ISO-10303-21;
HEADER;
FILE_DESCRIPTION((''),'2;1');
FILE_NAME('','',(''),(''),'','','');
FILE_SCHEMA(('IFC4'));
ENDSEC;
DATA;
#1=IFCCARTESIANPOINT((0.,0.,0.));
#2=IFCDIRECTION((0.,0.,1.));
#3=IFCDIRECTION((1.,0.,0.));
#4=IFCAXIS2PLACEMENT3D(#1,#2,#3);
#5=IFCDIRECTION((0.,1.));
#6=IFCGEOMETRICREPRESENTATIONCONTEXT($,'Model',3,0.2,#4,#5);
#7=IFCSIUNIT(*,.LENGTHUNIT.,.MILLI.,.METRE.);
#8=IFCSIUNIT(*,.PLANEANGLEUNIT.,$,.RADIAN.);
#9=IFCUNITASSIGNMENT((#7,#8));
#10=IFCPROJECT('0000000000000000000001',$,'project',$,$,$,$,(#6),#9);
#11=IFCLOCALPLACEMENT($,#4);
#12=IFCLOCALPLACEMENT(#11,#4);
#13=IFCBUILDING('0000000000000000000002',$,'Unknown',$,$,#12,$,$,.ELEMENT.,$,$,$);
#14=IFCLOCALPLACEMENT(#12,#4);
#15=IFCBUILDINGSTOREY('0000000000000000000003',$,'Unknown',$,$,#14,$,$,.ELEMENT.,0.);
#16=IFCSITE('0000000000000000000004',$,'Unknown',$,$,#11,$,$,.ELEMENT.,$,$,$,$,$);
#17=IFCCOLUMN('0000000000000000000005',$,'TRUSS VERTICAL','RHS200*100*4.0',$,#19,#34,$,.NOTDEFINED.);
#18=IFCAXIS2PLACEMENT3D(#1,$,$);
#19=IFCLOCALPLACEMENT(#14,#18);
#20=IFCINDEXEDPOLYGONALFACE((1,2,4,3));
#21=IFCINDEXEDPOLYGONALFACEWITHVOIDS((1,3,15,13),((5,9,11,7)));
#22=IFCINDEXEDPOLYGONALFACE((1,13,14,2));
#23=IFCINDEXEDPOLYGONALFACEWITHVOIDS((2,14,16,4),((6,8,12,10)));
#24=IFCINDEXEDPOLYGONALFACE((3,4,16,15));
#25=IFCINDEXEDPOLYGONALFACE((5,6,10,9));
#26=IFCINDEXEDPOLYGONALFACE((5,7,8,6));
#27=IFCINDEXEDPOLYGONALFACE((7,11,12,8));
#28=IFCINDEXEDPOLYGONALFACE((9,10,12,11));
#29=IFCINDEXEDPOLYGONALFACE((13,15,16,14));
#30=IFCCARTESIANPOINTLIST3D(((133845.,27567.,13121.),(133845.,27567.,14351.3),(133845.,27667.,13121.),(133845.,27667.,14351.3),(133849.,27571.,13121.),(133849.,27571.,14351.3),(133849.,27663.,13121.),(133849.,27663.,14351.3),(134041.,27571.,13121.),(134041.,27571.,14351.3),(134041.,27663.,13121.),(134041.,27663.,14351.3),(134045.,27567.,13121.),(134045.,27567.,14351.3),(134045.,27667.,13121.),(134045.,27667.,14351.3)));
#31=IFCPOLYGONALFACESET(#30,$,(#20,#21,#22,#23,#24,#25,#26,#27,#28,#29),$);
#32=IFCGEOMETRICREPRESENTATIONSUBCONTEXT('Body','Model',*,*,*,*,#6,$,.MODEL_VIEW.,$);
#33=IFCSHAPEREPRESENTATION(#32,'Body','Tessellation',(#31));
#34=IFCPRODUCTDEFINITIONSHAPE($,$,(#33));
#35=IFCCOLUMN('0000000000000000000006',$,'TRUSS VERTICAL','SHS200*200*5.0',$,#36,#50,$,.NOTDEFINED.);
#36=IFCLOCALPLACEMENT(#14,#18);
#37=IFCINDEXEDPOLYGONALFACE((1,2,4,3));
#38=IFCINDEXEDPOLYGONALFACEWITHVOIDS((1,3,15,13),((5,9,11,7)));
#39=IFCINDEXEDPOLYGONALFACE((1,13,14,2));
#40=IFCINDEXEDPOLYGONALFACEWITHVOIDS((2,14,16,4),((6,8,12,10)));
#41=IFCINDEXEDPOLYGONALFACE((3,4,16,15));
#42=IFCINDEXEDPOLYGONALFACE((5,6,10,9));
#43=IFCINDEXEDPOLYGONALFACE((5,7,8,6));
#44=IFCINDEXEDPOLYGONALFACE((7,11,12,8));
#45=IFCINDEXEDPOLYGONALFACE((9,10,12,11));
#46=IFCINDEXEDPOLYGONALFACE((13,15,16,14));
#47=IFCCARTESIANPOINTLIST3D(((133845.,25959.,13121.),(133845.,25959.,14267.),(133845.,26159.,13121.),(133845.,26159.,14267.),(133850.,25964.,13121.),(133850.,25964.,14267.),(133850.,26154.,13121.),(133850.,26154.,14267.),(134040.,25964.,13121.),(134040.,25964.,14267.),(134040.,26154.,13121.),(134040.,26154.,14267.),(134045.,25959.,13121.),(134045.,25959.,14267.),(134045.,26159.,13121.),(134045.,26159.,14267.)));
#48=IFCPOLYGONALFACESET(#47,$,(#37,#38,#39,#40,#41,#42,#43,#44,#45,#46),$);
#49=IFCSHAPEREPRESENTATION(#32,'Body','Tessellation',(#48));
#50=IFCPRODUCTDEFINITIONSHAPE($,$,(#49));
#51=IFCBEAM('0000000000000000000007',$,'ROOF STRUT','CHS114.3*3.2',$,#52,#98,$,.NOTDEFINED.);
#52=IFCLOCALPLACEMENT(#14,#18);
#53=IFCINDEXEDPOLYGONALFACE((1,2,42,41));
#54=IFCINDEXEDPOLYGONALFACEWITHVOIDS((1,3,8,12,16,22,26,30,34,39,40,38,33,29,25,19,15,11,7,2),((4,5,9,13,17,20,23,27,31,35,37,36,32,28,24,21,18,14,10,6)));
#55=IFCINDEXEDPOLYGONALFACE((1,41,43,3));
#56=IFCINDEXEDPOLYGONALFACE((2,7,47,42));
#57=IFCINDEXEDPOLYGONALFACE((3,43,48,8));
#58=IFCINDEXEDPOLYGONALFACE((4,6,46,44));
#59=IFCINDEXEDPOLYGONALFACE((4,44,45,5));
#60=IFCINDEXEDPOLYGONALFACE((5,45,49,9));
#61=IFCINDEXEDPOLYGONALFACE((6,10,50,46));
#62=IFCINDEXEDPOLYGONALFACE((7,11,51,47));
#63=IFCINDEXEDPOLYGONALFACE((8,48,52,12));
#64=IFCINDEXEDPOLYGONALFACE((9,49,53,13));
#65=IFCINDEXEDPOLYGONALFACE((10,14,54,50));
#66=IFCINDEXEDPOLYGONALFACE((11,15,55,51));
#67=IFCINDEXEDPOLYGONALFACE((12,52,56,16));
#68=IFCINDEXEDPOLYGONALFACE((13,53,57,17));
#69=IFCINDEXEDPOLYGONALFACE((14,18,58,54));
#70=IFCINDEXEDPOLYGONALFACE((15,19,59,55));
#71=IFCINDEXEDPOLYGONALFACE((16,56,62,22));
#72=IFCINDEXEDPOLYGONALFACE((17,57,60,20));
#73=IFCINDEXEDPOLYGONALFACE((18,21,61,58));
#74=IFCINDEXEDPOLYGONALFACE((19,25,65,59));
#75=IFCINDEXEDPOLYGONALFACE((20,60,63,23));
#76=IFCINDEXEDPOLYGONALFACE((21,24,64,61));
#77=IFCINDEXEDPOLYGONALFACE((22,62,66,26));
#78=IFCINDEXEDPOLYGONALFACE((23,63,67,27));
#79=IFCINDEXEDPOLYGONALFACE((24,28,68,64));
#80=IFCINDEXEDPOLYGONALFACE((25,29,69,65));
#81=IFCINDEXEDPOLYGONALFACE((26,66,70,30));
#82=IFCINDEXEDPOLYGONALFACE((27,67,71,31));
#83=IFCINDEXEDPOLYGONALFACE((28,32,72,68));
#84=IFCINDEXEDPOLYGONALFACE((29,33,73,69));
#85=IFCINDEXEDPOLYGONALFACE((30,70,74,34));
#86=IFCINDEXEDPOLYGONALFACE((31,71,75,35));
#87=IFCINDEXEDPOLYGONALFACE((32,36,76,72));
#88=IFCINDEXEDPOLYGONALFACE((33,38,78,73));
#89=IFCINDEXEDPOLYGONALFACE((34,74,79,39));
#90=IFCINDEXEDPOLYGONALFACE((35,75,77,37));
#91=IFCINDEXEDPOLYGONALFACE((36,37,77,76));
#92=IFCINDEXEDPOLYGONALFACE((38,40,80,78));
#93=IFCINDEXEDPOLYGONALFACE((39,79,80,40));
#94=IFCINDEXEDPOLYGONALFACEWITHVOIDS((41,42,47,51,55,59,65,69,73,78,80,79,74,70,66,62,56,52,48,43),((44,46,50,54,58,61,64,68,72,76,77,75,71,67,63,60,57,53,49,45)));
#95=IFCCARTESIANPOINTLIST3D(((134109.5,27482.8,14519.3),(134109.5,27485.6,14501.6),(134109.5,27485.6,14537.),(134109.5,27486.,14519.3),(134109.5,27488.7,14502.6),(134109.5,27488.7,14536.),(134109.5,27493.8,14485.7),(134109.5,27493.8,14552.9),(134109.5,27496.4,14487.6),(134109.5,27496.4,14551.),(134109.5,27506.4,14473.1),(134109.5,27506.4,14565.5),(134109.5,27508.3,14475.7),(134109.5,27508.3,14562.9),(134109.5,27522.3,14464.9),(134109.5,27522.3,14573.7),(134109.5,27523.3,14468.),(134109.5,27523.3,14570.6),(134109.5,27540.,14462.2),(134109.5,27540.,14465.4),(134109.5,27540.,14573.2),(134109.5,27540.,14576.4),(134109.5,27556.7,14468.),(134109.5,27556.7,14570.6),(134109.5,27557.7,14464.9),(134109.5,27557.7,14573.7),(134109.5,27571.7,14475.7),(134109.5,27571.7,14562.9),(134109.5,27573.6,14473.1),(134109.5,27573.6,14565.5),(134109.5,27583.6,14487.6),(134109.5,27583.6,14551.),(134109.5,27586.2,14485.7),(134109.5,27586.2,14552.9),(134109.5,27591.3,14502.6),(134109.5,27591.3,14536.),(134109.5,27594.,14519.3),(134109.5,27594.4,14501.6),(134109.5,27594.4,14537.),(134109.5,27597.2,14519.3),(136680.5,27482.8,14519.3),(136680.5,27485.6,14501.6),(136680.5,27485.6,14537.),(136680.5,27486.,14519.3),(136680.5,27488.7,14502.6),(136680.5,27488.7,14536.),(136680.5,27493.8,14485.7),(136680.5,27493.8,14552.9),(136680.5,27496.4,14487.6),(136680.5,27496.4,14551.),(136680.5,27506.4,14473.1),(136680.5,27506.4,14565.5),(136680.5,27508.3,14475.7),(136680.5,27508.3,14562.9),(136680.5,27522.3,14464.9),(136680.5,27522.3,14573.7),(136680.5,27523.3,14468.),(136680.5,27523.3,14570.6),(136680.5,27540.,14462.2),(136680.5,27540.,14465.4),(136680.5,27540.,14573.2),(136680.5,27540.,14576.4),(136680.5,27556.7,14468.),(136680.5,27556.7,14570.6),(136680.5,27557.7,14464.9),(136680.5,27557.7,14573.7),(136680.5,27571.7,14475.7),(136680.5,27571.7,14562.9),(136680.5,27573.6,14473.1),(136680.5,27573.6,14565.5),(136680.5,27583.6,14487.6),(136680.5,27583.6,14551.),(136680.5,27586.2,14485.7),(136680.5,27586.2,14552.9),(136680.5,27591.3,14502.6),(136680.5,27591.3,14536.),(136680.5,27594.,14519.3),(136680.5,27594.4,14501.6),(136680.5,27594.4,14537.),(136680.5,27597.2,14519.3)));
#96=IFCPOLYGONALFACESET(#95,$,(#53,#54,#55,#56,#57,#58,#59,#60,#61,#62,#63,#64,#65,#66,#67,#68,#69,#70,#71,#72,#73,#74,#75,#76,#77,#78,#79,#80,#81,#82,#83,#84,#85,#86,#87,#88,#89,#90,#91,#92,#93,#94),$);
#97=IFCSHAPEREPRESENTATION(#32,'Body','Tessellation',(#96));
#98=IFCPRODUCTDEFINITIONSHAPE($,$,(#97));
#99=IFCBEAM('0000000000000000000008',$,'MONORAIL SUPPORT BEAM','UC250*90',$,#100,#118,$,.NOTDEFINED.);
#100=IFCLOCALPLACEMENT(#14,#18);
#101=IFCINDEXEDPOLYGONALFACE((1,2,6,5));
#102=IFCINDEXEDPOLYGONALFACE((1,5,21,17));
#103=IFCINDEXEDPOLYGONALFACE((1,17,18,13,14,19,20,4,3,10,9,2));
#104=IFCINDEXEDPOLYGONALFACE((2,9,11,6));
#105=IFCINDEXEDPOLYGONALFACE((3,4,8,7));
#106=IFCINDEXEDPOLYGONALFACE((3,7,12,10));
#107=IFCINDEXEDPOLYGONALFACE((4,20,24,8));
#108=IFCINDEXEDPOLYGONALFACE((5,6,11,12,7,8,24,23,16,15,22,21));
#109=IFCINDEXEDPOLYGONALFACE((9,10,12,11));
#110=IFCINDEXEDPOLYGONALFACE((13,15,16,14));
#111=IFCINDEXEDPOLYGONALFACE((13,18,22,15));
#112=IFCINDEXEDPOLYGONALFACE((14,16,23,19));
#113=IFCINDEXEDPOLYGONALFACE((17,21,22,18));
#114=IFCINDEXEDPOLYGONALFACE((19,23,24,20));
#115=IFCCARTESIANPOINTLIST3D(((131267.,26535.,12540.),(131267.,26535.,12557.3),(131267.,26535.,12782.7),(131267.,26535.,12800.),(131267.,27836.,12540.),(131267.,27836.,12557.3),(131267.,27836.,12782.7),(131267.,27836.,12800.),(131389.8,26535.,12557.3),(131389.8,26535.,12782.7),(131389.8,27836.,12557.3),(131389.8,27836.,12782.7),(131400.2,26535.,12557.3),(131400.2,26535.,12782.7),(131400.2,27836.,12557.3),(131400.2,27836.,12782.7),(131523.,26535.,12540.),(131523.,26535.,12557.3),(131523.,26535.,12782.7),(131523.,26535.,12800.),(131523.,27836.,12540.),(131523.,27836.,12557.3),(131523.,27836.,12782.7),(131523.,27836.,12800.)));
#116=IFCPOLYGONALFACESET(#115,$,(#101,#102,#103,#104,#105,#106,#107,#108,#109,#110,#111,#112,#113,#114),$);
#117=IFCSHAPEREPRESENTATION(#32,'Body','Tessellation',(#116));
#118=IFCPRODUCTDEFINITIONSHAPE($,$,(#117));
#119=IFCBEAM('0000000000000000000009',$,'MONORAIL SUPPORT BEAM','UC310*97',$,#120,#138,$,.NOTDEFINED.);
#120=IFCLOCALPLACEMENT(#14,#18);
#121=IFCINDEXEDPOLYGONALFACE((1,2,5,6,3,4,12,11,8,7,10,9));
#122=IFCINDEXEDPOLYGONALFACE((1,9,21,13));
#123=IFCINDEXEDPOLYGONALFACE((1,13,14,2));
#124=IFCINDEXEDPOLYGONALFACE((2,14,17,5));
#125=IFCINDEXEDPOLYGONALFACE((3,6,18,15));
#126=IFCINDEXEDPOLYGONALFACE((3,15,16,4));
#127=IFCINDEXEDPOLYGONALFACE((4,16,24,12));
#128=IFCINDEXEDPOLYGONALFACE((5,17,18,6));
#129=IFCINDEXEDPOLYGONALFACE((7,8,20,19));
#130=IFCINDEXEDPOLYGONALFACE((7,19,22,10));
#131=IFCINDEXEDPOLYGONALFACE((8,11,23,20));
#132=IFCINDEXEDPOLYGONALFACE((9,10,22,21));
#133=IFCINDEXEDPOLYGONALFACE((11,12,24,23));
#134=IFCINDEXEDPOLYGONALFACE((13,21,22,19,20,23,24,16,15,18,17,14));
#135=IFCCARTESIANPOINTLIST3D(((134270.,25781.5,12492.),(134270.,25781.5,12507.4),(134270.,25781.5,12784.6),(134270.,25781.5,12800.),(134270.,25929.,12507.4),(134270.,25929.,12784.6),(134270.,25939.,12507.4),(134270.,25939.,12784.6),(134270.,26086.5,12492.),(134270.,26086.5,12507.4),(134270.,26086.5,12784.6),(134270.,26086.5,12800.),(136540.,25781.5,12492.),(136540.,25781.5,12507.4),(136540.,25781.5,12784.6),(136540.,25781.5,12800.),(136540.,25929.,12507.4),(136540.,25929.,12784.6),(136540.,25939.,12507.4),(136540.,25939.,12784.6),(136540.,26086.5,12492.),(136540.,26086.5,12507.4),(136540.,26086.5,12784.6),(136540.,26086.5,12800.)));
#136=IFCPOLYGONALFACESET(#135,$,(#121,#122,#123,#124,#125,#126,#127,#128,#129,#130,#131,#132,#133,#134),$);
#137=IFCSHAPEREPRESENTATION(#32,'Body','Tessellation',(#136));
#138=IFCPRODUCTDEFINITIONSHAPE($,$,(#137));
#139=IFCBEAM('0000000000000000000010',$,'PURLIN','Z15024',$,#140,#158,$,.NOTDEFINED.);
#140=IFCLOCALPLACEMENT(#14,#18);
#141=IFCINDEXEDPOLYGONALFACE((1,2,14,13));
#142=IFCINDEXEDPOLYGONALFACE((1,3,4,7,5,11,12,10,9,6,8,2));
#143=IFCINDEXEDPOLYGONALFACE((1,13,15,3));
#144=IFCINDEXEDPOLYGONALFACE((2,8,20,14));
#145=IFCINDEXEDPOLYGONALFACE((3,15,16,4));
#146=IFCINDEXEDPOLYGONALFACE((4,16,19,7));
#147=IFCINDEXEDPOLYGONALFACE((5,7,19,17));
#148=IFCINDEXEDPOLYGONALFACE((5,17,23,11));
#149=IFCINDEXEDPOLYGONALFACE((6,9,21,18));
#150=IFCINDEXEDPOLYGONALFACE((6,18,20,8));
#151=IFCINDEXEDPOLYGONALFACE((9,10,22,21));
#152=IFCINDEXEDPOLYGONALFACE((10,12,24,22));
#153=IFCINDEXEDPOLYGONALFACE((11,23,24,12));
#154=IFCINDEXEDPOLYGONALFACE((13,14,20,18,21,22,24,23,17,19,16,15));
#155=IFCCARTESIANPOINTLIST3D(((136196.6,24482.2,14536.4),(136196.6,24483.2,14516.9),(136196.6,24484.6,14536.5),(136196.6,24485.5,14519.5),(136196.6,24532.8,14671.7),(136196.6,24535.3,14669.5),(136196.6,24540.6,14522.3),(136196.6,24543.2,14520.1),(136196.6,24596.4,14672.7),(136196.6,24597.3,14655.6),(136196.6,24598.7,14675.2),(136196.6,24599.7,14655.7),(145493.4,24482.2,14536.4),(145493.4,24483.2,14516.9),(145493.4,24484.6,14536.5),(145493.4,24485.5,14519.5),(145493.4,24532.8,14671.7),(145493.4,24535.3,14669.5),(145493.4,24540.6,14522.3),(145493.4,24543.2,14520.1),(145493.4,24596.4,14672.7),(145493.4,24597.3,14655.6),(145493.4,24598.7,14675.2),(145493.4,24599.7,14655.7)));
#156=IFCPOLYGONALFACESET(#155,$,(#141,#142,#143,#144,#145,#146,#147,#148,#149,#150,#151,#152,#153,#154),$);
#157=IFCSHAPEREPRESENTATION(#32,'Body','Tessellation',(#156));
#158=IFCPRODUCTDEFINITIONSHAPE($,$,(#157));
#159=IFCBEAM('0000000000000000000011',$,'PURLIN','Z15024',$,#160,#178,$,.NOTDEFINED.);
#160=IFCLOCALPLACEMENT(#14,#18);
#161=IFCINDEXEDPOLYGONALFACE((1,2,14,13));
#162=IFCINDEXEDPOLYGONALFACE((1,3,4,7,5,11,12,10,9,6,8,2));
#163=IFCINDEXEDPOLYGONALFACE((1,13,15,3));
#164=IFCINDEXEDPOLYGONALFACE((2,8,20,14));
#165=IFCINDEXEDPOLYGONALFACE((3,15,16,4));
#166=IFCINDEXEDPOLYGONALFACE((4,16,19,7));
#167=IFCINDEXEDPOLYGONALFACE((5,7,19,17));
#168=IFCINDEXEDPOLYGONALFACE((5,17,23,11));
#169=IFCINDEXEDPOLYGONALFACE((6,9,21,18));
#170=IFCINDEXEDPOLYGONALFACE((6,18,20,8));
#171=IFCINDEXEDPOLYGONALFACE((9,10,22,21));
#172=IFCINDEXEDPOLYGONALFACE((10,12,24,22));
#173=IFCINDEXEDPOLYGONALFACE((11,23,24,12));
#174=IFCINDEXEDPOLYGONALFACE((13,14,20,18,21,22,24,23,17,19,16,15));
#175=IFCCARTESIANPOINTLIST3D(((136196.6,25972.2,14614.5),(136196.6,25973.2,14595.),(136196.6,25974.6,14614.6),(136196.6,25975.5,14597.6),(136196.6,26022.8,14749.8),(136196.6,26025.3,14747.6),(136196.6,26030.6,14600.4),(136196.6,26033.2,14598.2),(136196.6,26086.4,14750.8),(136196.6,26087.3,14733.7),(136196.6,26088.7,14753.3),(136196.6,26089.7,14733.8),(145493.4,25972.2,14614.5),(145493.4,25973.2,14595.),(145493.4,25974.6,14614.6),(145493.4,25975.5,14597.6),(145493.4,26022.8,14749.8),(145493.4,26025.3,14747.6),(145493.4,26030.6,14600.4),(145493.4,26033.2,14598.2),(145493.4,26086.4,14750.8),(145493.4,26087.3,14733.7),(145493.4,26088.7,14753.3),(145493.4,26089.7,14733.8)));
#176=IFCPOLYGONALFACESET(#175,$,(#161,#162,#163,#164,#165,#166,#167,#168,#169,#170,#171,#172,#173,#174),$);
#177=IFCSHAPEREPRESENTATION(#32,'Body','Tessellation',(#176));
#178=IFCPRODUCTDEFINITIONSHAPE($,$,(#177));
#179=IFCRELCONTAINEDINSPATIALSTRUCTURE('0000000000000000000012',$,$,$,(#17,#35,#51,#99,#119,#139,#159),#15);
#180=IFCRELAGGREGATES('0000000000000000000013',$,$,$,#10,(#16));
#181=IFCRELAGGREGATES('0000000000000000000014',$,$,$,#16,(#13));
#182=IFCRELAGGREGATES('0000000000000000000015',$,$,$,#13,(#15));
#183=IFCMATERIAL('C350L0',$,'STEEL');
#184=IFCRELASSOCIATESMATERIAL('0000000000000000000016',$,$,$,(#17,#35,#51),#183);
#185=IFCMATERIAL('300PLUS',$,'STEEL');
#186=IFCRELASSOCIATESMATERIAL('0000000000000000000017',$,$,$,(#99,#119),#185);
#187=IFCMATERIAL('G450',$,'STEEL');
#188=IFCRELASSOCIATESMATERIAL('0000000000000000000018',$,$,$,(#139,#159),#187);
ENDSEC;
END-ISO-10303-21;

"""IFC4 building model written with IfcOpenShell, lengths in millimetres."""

from ifc_helpers import new_model, si_unit, direction, frame, origin_with_axes, place, context, subcontext, project, spatial, line, indexed_curve, outline, extrude, material, element, save


model = new_model("IFC4")

# Units and contexts
model_context = context("Model", 3, precision=0.2, world=origin_with_axes(), true_north=direction((0.0, 1.0)))
body_context = subcontext(model_context, "Body", "Model", "MODEL_VIEW")
ifc_project = project(units=[si_unit("LENGTHUNIT", "METRE", prefix="MILLI"), si_unit("PLANEANGLEUNIT", "RADIAN")], contexts=[model_context])

# Site, building, storey
site_placement = place(None, origin_with_axes())
site = spatial("IfcSite", under=ifc_project, at=site_placement, Name="Unknown", CompositionType="ELEMENT")
building_placement = place(site_placement, origin_with_axes())
building = spatial("IfcBuilding", under=site, at=building_placement, Name="Unknown", CompositionType="ELEMENT")
storey_placement = place(building_placement, origin_with_axes())
storey = spatial("IfcBuildingStorey", under=building, at=storey_placement, Name="Unknown", CompositionType="ELEMENT", Elevation=0.0)

# Columns
ifc_material_1 = material(Name="C350L0", Category="STEEL")
column_1_placement = place(storey_placement, frame((133945.0, 27617.0, 13121.0), z_axis=(0.0, -1.0, 0.0), x_axis=(0.0, 0.0, 1.0)))
element("IfcColumn", 1, at=column_1_placement, inside=storey, material=ifc_material_1, Name="TRUSS VERTICAL", Description="RHS200*100*4.0", PredefinedType="NOTDEFINED", context=body_context, shape_type="SolidModel", body=[
    extrude(outline(indexed_curve([(-50.0, -100.0), (50.0, -100.0), (50.0, 100.0), (-50.0, 100.0)], segments=[line(1, 2, 3, 4, 1)]), holes=[indexed_curve([(-46.0, -96.0), (-46.0, 96.0), (46.0, 96.0), (46.0, -96.0)], segments=[line(1, 2, 3, 4, 1)])]), frame((0.0, 0.0, 0.0), z_axis=(-1.0, 0.0, 0.0), x_axis=(0.0, 0.0, 1.0)), (0.0, 0.0, -1.0), 1230.3),
])
column_2_placement = place(storey_placement, frame((133945.0, 26059.0, 13121.0), z_axis=(-1.0, 0.0, 0.0), x_axis=(0.0, 0.0, 1.0)))
element("IfcColumn", 2, at=column_2_placement, inside=storey, material=ifc_material_1, Name="TRUSS VERTICAL", Description="SHS200*200*5.0", PredefinedType="NOTDEFINED", context=body_context, shape_type="SolidModel", body=[
    extrude(outline(indexed_curve([(-100.0, -100.0), (100.0, -100.0), (100.0, 100.0), (-100.0, 100.0)], segments=[line(1, 2, 3, 4, 1)]), holes=[indexed_curve([(-95.0, -95.0), (-95.0, 95.0), (95.0, 95.0), (95.0, -95.0)], segments=[line(1, 2, 3, 4, 1)])]), frame((0.0, 0.0, 0.0), z_axis=(-1.0, 0.0, 0.0), x_axis=(0.0, 0.0, 1.0)), (0.0, 0.0, -1.0), 1146.0),
])

# Beams
beam_1_placement = place(storey_placement, frame((134109.5, 27540.0, 14519.3), z_axis=(0.0, 0.0, 1.0), x_axis=(1.0, 0.0, 0.0)))
element("IfcBeam", 3, at=beam_1_placement, inside=storey, material=ifc_material_1, Name="ROOF STRUT", Description="CHS114.3*3.2", PredefinedType="NOTDEFINED", context=body_context, shape_type="SolidModel", body=[
    extrude(outline(indexed_curve([(57.1, 0.0), (54.4, 17.7), (46.2, 33.6), (33.6, 46.2), (17.7, 54.4), (0.0, 57.1), (-17.7, 54.4), (-33.6, 46.2), (-46.2, 33.6), (-54.4, 17.7), (-57.1, 0.0), (-54.4, -17.7), (-46.2, -33.6), (-33.6, -46.2), (-17.7, -54.4), (0.0, -57.1), (17.7, -54.4), (33.6, -46.2), (46.2, -33.6), (54.4, -17.7)], segments=[line(1, 2, 3, 4, 5, 6, 7, 8, 9, 10, 11, 12, 13, 14, 15, 16, 17, 18, 19, 20, 1)]), holes=[indexed_curve([(54.0, 0.0), (51.3, -16.7), (43.6, -31.7), (31.7, -43.6), (16.7, -51.3), (0.0, -54.0), (-16.7, -51.3), (-31.7, -43.6), (-43.6, -31.7), (-51.3, -16.7), (-54.0, 0.0), (-51.3, 16.7), (-43.6, 31.7), (-31.7, 43.6), (-16.7, 51.3), (0.0, 54.0), (16.7, 51.3), (31.7, 43.6), (43.6, 31.7), (51.3, 16.7)], segments=[line(1, 2, 3, 4, 5, 6, 7, 8, 9, 10, 11, 12, 13, 14, 15, 16, 17, 18, 19, 20, 1)])]), frame((0.0, 0.0, 0.0), z_axis=(-1.0, 0.0, 0.0), x_axis=(0.0, 0.0, 1.0)), (0.0, 0.0, -1.0), 2571.0),
])
ifc_material_2 = material(Name="300PLUS", Category="STEEL")
beam_2_placement = place(storey_placement, frame((131395.0, 26535.0, 12670.0), z_axis=(1.0, 0.0, 0.0), x_axis=(0.0, 1.0, 0.0)))
element("IfcBeam", 4, at=beam_2_placement, inside=storey, material=ifc_material_2, Name="MONORAIL SUPPORT BEAM", Description="UC250*90", PredefinedType="NOTDEFINED", context=body_context, shape_type="SolidModel", body=[
    extrude(outline(indexed_curve([(-128.0, -130.0), (128.0, -130.0), (128.0, -112.7), (5.2, -112.7), (5.2, 112.7), (128.0, 112.7), (128.0, 130.0), (-128.0, 130.0), (-128.0, 112.7), (-5.2, 112.7), (-5.2, -112.7), (-128.0, -112.7)], segments=[line(1, 2, 3, 4, 5, 6, 7, 8, 9, 10, 11, 12, 1)])), frame((0.0, 0.0, 0.0), z_axis=(-1.0, 0.0, 0.0), x_axis=(0.0, 0.0, 1.0)), (0.0, 0.0, -1.0), 1301.0),
])
beam_3_placement = place(storey_placement, frame((134270.0, 25934.0, 12646.0), z_axis=(0.0, -1.0, 0.0), x_axis=(1.0, 0.0, 0.0)))
element("IfcBeam", 5, at=beam_3_placement, inside=storey, material=ifc_material_2, Name="MONORAIL SUPPORT BEAM", Description="UC310*97", PredefinedType="NOTDEFINED", context=body_context, shape_type="SolidModel", body=[
    extrude(outline(indexed_curve([(-152.5, -154.0), (152.5, -154.0), (152.5, -138.6), (5.0, -138.6), (5.0, 138.6), (152.5, 138.6), (152.5, 154.0), (-152.5, 154.0), (-152.5, 138.6), (-5.0, 138.6), (-5.0, -138.6), (-152.5, -138.6)], segments=[line(1, 2, 3, 4, 5, 6, 7, 8, 9, 10, 11, 12, 1)])), frame((0.0, 0.0, 0.0), z_axis=(-1.0, 0.0, 0.0), x_axis=(0.0, 0.0, 1.0)), (0.0, 0.0, -1.0), 2270.0),
])
ifc_material_3 = material(Name="G450", Category="STEEL")
for number, where, z_axis, x_axis, name in (
    (6, (136196.6, 24538.0, 14595.9), (0.0, -0.99863, -0.052336), (1.0, 0.0, 0.0), "PURLIN"),
    (7, (136196.6, 26028.0, 14674.0), (0.0, -0.99863, -0.052336), (1.0, 0.0, 0.0), "PURLIN"),
):
    element("IfcBeam", number, at=place(storey_placement, frame(where, z_axis=z_axis, x_axis=x_axis)), inside=storey, material=ifc_material_3, Name=name, Description="Z15024", PredefinedType="NOTDEFINED", context=body_context, shape_type="SolidModel", body=[
        extrude(outline(indexed_curve([(58.8, -76.0), (58.8, -56.5), (56.4, -56.5), (56.4, -73.6), (1.2, -73.6), (1.2, 76.0), (-64.8, 76.0), (-64.8, 56.5), (-62.4, 56.5), (-62.4, 73.6), (-1.2, 73.6), (-1.2, -76.0)], segments=[line(1, 2, 3, 4, 5, 6, 7, 8, 9, 10, 11, 12, 1)])), frame((0.0, 0.0, 0.0), z_axis=(-1.0, 0.0, 0.0), x_axis=(0.0, 0.0, 1.0)), (0.0, 0.0, -1.0), 9296.8),
    ])

save(model, "model.ifc")
